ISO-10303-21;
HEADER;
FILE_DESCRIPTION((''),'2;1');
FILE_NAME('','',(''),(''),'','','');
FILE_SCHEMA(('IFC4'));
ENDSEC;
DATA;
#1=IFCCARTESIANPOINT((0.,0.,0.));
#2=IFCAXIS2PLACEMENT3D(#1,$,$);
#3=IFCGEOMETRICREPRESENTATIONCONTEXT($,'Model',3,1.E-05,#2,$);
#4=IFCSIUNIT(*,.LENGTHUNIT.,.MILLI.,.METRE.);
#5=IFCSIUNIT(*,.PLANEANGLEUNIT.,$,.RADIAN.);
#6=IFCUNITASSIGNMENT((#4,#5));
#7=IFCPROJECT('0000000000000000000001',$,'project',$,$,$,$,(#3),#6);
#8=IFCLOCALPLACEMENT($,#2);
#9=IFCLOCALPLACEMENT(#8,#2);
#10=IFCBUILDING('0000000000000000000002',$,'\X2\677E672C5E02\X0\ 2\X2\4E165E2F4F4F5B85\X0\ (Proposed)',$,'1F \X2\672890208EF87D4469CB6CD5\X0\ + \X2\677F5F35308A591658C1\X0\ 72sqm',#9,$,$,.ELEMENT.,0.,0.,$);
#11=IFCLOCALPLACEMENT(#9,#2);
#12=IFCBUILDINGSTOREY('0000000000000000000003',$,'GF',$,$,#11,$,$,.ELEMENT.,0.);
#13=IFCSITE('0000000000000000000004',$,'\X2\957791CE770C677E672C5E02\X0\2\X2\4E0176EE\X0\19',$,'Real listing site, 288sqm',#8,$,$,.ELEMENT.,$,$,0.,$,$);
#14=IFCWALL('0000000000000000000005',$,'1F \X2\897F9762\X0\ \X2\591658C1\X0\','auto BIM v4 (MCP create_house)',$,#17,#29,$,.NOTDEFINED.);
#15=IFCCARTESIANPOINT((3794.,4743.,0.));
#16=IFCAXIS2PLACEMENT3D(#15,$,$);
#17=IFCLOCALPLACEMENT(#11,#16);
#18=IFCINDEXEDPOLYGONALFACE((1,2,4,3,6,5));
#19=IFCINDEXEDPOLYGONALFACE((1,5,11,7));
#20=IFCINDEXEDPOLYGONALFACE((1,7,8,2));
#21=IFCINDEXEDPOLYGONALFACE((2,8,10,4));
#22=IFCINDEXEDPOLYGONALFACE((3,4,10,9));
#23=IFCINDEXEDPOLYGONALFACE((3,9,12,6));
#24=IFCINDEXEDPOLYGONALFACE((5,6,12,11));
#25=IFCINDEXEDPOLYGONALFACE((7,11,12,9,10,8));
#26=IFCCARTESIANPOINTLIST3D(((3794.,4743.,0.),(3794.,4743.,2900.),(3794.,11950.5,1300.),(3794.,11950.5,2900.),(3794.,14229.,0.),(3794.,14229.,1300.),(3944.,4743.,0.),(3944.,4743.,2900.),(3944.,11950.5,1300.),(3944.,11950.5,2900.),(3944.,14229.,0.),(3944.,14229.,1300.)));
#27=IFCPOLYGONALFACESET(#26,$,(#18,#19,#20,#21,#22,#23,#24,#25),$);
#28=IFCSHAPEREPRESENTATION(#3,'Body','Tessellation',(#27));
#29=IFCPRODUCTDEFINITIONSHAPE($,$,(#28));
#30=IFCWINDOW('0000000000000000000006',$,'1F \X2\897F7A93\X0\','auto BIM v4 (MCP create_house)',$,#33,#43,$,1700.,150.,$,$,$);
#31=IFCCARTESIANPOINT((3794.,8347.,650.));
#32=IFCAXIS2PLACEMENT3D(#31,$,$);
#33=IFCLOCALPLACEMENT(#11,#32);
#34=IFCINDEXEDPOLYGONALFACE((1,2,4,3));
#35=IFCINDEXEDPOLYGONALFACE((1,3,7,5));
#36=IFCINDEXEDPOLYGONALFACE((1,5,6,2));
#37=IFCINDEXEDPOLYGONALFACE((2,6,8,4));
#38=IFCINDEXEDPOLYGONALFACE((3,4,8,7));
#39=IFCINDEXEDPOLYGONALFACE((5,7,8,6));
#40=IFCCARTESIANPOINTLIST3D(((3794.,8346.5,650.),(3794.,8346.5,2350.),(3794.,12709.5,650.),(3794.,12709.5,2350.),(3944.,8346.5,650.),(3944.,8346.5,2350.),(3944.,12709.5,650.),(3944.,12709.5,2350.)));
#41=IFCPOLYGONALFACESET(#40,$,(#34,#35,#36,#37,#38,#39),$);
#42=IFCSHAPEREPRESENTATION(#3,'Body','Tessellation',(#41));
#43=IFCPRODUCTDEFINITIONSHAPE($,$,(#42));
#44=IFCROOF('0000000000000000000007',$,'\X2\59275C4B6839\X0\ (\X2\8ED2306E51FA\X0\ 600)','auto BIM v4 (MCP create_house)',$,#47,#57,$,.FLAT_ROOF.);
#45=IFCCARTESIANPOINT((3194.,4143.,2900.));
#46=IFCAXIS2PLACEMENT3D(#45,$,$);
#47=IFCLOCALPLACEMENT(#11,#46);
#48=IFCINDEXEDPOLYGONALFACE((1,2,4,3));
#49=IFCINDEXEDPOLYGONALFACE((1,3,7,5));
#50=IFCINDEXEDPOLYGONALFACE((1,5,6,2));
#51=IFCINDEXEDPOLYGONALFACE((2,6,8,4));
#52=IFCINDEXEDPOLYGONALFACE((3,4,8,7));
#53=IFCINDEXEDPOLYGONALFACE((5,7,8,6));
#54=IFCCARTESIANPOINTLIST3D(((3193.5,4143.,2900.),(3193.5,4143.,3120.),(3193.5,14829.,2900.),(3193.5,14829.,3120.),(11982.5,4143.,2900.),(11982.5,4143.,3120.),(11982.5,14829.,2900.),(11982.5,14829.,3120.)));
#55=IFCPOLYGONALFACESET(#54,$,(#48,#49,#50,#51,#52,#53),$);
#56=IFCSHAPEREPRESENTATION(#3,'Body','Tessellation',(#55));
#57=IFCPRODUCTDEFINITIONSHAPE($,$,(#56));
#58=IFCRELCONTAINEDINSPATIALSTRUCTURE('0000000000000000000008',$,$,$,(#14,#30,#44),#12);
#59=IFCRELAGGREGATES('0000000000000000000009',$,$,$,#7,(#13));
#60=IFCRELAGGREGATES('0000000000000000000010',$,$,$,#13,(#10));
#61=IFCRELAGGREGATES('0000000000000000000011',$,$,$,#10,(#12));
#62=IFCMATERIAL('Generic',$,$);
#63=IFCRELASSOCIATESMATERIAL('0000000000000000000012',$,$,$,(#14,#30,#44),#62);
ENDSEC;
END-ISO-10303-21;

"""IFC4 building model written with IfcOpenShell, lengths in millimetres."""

from ifc_helpers import new_model, si_unit, frame, frame_2d, origin, place, context, project, spatial, rectangle, extrude, material, element, fill, save


model = new_model("IFC4")

# Units and contexts
model_context = context("Model", 3, precision=1e-05, world=origin())
ifc_project = project(units=[si_unit("LENGTHUNIT", "METRE", prefix="MILLI"), si_unit("PLANEANGLEUNIT", "RADIAN")], contexts=[model_context])

# Site, building, storey
site_placement = place(None, origin())
site = spatial("IfcSite", under=ifc_project, at=site_placement, Name="長野県松本市2丁目19", ObjectType="Real listing site, 288sqm", CompositionType="ELEMENT", RefElevation=0.0)
building_placement = place(site_placement, origin())
building = spatial("IfcBuilding", under=site, at=building_placement, Name="松本市 2世帯住宅 (Proposed)", ObjectType="1F 木造軸組構法 + 板張り外壁 72sqm", CompositionType="ELEMENT", ElevationOfRefHeight=0.0, ElevationOfTerrain=0.0)
storey_placement = place(building_placement, origin())
storey = spatial("IfcBuildingStorey", under=building, at=storey_placement, Name="GF", CompositionType="ELEMENT", Elevation=0.0)

# Shared definitions
ifc_material = material(Name="Generic")

# Wall, opening, window
wall_1_placement = place(storey_placement, frame((3794.0, 4743.0, 0.0)))
wall_1 = element("IfcWall", 1, at=wall_1_placement, inside=storey, material=ifc_material, Name="1F 西面 外壁", Description="auto BIM v4 (MCP create_house)", PredefinedType="NOTDEFINED", context=model_context, shape_type="SweptSolid", body=[
    extrude(rectangle(XDim=150.0, YDim=9486.0, at=frame_2d((75.0, 4743.0))), frame((3794.0, 4743.0, 0.0)), (0.0, 0.0, 1.0), 2900.0),
])
opening_1_placement = place(storey_placement, frame((3794.0, 8347.0, 650.0)))
opening_1 = element("IfcOpeningElement", 2, at=opening_1_placement, cuts=wall_1, PredefinedType="NOTDEFINED", context=model_context, shape_type="SweptSolid", body=[
    extrude(rectangle(XDim=150.0, YDim=4363.0, at=frame_2d((75.0, 2181.0))), frame((3794.0, 8347.0, 650.0)), (0.0, 0.0, 1.0), 1700.0),
])
window_1_placement = place(storey_placement, frame((3794.0, 8347.0, 650.0)))
window_1 = element("IfcWindow", 3, at=window_1_placement, inside=storey, material=ifc_material, Name="1F 西窓", Description="auto BIM v4 (MCP create_house)", OverallHeight=1700.0, OverallWidth=150.0, context=model_context, shape_type="SweptSolid", body=[
    extrude(rectangle(XDim=150.0, YDim=4363.0, at=frame_2d((75.0, 2181.0))), frame((3794.0, 8347.0, 650.0)), (0.0, 0.0, 1.0), 1700.0),
])
fill(opening_1, window_1)

# Roof
roof_placement = place(storey_placement, frame((3194.0, 4143.0, 2900.0)))
element("IfcRoof", 4, at=roof_placement, inside=storey, material=ifc_material, Name="大屋根 (軒の出 600)", Description="auto BIM v4 (MCP create_house)", PredefinedType="FLAT_ROOF", context=model_context, shape_type="SweptSolid", body=[
    extrude(rectangle(XDim=8789.0, YDim=10686.0, at=frame_2d((4394.0, 5343.0))), frame((3194.0, 4143.0, 2900.0)), (0.0, 0.0, 1.0), 220.0),
])

save(model, "model.ifc")
